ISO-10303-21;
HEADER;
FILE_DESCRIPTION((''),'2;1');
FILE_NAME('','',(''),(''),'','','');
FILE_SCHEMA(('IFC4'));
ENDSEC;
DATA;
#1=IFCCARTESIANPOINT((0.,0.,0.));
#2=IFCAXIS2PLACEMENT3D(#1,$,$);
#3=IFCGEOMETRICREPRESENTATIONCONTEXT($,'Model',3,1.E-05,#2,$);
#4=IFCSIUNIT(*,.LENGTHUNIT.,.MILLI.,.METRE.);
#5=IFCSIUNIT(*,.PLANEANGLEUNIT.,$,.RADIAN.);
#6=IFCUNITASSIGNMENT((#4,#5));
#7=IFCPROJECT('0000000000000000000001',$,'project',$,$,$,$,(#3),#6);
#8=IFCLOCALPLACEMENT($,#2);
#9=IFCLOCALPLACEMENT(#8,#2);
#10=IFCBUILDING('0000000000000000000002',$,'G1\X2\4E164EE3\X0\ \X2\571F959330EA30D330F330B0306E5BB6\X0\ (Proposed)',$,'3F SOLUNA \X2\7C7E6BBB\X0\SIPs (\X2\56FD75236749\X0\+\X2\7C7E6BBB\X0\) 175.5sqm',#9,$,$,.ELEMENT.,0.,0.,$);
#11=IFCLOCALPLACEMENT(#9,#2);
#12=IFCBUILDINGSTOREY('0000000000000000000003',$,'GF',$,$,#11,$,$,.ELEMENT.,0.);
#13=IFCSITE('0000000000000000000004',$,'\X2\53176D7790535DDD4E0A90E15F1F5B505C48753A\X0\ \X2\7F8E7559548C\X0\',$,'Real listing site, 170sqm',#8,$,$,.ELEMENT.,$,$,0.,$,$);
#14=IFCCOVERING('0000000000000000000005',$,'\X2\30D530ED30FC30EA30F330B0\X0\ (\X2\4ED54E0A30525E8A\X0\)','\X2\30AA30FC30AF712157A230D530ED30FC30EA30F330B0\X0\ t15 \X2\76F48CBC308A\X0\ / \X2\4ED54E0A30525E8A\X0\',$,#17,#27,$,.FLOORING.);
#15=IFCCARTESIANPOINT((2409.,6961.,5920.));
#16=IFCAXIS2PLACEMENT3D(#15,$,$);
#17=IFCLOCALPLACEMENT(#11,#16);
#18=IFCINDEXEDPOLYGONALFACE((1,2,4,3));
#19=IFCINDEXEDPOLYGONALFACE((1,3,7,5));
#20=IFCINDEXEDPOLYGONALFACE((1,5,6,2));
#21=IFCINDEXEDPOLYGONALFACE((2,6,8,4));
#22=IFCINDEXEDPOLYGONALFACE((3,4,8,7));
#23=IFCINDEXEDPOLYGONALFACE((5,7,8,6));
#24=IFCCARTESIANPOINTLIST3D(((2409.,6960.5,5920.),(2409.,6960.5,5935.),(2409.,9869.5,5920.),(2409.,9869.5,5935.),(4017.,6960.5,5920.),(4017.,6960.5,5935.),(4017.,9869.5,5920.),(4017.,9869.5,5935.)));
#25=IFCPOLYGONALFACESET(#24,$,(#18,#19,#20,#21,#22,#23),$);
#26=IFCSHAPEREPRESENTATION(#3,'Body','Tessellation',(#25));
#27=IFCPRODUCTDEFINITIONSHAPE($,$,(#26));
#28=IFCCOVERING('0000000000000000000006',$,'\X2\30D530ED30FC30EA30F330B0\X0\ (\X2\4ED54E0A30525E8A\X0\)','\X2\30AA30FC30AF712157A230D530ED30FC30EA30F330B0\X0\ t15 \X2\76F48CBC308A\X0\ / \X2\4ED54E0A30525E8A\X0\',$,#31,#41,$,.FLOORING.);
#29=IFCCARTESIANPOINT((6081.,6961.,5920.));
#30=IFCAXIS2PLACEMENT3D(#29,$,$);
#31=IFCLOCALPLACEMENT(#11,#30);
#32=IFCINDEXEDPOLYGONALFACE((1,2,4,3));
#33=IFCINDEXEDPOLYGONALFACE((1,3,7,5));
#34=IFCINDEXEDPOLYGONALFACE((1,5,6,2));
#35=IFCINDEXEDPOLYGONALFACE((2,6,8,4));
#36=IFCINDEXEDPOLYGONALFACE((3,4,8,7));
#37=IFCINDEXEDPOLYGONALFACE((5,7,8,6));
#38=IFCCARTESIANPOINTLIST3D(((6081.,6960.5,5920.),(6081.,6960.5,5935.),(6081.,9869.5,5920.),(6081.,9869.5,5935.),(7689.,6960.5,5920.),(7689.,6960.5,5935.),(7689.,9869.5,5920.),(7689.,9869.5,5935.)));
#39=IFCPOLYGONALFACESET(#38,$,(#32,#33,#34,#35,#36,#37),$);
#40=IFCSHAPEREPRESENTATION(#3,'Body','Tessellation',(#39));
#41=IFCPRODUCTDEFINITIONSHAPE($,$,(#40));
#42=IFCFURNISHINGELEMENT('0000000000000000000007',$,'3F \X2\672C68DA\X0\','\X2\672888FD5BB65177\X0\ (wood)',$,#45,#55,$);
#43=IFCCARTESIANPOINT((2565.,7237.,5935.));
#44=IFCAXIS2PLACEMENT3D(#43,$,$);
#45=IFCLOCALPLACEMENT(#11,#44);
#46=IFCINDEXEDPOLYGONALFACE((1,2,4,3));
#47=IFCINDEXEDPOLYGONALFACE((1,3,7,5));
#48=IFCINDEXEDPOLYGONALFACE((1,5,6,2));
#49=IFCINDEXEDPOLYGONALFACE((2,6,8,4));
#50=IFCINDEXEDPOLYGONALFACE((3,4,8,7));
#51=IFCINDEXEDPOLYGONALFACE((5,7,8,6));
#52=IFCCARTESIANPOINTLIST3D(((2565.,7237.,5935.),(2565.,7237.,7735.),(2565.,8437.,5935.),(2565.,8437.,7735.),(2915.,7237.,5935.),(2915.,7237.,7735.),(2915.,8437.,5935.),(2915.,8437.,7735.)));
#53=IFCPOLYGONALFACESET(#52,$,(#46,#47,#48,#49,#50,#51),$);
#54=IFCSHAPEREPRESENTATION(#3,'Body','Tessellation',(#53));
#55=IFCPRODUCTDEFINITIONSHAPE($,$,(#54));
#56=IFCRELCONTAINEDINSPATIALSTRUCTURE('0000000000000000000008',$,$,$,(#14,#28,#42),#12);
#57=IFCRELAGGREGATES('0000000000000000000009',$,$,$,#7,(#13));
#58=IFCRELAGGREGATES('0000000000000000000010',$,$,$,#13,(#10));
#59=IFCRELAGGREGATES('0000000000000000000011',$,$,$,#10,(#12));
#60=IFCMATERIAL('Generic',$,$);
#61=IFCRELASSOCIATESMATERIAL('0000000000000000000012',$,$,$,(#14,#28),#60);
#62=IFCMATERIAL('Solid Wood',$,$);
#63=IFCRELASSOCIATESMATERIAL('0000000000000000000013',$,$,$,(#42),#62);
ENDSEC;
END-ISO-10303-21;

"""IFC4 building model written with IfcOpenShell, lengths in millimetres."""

from ifc_helpers import new_model, si_unit, frame, frame_2d, origin, place, context, project, spatial, rectangle, extrude, material, element, save


model = new_model("IFC4")

# Units and contexts
model_context = context("Model", 3, precision=1e-05, world=origin())
ifc_project = project(units=[si_unit("LENGTHUNIT", "METRE", prefix="MILLI"), si_unit("PLANEANGLEUNIT", "RADIAN")], contexts=[model_context])

# Site, building, storey
site_placement = place(None, origin())
site = spatial("IfcSite", under=ifc_project, at=site_placement, Name="北海道川上郡弟子屈町 美留和", ObjectType="Real listing site, 170sqm", CompositionType="ELEMENT", RefElevation=0.0)
building_placement = place(site_placement, origin())
building = spatial("IfcBuilding", under=site, at=building_placement, Name="G1世代 土間リビングの家 (Proposed)", ObjectType="3F SOLUNA 籾殻SIPs (国産杉+籾殻) 175.5sqm", CompositionType="ELEMENT", ElevationOfRefHeight=0.0, ElevationOfTerrain=0.0)
storey_placement = place(building_placement, origin())
storey = spatial("IfcBuildingStorey", under=building, at=storey_placement, Name="GF", CompositionType="ELEMENT", Elevation=0.0)

# Shared definitions
ifc_material_1 = material(Name="Solid Wood")

# Shared definitions
ifc_material_2 = material(Name="Generic")

# Coverings
covering_1_placement = place(storey_placement, frame((2409.0, 6961.0, 5920.0)))
element("IfcCovering", 1, at=covering_1_placement, inside=storey, material=ifc_material_2, Name="フローリング (仕上げ床)", Description="オーク無垢フローリング t15 直貼り / 仕上げ床", PredefinedType="FLOORING", context=model_context, shape_type="SweptSolid", body=[
    extrude(rectangle(XDim=1608.0, YDim=2909.0, at=frame_2d((804.0, 1454.0))), frame((2409.0, 6961.0, 5920.0)), (0.0, 0.0, 1.0), 15.0),
])
covering_2_placement = place(storey_placement, frame((6081.0, 6961.0, 5920.0)))
element("IfcCovering", 2, at=covering_2_placement, inside=storey, material=ifc_material_2, Name="フローリング (仕上げ床)", Description="オーク無垢フローリング t15 直貼り / 仕上げ床", PredefinedType="FLOORING", context=model_context, shape_type="SweptSolid", body=[
    extrude(rectangle(XDim=1608.0, YDim=2909.0, at=frame_2d((804.0, 1454.0))), frame((6081.0, 6961.0, 5920.0)), (0.0, 0.0, 1.0), 15.0),
])

# Furnishing element
furnishing_placement = place(storey_placement, frame((2565.0, 7237.0, 5935.0)))
element("IfcFurnishingElement", 3, at=furnishing_placement, inside=storey, material=ifc_material_1, Name="3F 本棚", Description="木製家具 (wood)", context=model_context, shape_type="SweptSolid", body=[
    extrude(rectangle(XDim=350.0, YDim=1200.0, at=frame_2d((175.0, 600.0))), frame((2565.0, 7237.0, 5935.0)), (0.0, 0.0, 1.0), 1800.0),
])

save(model, "model.ifc")
